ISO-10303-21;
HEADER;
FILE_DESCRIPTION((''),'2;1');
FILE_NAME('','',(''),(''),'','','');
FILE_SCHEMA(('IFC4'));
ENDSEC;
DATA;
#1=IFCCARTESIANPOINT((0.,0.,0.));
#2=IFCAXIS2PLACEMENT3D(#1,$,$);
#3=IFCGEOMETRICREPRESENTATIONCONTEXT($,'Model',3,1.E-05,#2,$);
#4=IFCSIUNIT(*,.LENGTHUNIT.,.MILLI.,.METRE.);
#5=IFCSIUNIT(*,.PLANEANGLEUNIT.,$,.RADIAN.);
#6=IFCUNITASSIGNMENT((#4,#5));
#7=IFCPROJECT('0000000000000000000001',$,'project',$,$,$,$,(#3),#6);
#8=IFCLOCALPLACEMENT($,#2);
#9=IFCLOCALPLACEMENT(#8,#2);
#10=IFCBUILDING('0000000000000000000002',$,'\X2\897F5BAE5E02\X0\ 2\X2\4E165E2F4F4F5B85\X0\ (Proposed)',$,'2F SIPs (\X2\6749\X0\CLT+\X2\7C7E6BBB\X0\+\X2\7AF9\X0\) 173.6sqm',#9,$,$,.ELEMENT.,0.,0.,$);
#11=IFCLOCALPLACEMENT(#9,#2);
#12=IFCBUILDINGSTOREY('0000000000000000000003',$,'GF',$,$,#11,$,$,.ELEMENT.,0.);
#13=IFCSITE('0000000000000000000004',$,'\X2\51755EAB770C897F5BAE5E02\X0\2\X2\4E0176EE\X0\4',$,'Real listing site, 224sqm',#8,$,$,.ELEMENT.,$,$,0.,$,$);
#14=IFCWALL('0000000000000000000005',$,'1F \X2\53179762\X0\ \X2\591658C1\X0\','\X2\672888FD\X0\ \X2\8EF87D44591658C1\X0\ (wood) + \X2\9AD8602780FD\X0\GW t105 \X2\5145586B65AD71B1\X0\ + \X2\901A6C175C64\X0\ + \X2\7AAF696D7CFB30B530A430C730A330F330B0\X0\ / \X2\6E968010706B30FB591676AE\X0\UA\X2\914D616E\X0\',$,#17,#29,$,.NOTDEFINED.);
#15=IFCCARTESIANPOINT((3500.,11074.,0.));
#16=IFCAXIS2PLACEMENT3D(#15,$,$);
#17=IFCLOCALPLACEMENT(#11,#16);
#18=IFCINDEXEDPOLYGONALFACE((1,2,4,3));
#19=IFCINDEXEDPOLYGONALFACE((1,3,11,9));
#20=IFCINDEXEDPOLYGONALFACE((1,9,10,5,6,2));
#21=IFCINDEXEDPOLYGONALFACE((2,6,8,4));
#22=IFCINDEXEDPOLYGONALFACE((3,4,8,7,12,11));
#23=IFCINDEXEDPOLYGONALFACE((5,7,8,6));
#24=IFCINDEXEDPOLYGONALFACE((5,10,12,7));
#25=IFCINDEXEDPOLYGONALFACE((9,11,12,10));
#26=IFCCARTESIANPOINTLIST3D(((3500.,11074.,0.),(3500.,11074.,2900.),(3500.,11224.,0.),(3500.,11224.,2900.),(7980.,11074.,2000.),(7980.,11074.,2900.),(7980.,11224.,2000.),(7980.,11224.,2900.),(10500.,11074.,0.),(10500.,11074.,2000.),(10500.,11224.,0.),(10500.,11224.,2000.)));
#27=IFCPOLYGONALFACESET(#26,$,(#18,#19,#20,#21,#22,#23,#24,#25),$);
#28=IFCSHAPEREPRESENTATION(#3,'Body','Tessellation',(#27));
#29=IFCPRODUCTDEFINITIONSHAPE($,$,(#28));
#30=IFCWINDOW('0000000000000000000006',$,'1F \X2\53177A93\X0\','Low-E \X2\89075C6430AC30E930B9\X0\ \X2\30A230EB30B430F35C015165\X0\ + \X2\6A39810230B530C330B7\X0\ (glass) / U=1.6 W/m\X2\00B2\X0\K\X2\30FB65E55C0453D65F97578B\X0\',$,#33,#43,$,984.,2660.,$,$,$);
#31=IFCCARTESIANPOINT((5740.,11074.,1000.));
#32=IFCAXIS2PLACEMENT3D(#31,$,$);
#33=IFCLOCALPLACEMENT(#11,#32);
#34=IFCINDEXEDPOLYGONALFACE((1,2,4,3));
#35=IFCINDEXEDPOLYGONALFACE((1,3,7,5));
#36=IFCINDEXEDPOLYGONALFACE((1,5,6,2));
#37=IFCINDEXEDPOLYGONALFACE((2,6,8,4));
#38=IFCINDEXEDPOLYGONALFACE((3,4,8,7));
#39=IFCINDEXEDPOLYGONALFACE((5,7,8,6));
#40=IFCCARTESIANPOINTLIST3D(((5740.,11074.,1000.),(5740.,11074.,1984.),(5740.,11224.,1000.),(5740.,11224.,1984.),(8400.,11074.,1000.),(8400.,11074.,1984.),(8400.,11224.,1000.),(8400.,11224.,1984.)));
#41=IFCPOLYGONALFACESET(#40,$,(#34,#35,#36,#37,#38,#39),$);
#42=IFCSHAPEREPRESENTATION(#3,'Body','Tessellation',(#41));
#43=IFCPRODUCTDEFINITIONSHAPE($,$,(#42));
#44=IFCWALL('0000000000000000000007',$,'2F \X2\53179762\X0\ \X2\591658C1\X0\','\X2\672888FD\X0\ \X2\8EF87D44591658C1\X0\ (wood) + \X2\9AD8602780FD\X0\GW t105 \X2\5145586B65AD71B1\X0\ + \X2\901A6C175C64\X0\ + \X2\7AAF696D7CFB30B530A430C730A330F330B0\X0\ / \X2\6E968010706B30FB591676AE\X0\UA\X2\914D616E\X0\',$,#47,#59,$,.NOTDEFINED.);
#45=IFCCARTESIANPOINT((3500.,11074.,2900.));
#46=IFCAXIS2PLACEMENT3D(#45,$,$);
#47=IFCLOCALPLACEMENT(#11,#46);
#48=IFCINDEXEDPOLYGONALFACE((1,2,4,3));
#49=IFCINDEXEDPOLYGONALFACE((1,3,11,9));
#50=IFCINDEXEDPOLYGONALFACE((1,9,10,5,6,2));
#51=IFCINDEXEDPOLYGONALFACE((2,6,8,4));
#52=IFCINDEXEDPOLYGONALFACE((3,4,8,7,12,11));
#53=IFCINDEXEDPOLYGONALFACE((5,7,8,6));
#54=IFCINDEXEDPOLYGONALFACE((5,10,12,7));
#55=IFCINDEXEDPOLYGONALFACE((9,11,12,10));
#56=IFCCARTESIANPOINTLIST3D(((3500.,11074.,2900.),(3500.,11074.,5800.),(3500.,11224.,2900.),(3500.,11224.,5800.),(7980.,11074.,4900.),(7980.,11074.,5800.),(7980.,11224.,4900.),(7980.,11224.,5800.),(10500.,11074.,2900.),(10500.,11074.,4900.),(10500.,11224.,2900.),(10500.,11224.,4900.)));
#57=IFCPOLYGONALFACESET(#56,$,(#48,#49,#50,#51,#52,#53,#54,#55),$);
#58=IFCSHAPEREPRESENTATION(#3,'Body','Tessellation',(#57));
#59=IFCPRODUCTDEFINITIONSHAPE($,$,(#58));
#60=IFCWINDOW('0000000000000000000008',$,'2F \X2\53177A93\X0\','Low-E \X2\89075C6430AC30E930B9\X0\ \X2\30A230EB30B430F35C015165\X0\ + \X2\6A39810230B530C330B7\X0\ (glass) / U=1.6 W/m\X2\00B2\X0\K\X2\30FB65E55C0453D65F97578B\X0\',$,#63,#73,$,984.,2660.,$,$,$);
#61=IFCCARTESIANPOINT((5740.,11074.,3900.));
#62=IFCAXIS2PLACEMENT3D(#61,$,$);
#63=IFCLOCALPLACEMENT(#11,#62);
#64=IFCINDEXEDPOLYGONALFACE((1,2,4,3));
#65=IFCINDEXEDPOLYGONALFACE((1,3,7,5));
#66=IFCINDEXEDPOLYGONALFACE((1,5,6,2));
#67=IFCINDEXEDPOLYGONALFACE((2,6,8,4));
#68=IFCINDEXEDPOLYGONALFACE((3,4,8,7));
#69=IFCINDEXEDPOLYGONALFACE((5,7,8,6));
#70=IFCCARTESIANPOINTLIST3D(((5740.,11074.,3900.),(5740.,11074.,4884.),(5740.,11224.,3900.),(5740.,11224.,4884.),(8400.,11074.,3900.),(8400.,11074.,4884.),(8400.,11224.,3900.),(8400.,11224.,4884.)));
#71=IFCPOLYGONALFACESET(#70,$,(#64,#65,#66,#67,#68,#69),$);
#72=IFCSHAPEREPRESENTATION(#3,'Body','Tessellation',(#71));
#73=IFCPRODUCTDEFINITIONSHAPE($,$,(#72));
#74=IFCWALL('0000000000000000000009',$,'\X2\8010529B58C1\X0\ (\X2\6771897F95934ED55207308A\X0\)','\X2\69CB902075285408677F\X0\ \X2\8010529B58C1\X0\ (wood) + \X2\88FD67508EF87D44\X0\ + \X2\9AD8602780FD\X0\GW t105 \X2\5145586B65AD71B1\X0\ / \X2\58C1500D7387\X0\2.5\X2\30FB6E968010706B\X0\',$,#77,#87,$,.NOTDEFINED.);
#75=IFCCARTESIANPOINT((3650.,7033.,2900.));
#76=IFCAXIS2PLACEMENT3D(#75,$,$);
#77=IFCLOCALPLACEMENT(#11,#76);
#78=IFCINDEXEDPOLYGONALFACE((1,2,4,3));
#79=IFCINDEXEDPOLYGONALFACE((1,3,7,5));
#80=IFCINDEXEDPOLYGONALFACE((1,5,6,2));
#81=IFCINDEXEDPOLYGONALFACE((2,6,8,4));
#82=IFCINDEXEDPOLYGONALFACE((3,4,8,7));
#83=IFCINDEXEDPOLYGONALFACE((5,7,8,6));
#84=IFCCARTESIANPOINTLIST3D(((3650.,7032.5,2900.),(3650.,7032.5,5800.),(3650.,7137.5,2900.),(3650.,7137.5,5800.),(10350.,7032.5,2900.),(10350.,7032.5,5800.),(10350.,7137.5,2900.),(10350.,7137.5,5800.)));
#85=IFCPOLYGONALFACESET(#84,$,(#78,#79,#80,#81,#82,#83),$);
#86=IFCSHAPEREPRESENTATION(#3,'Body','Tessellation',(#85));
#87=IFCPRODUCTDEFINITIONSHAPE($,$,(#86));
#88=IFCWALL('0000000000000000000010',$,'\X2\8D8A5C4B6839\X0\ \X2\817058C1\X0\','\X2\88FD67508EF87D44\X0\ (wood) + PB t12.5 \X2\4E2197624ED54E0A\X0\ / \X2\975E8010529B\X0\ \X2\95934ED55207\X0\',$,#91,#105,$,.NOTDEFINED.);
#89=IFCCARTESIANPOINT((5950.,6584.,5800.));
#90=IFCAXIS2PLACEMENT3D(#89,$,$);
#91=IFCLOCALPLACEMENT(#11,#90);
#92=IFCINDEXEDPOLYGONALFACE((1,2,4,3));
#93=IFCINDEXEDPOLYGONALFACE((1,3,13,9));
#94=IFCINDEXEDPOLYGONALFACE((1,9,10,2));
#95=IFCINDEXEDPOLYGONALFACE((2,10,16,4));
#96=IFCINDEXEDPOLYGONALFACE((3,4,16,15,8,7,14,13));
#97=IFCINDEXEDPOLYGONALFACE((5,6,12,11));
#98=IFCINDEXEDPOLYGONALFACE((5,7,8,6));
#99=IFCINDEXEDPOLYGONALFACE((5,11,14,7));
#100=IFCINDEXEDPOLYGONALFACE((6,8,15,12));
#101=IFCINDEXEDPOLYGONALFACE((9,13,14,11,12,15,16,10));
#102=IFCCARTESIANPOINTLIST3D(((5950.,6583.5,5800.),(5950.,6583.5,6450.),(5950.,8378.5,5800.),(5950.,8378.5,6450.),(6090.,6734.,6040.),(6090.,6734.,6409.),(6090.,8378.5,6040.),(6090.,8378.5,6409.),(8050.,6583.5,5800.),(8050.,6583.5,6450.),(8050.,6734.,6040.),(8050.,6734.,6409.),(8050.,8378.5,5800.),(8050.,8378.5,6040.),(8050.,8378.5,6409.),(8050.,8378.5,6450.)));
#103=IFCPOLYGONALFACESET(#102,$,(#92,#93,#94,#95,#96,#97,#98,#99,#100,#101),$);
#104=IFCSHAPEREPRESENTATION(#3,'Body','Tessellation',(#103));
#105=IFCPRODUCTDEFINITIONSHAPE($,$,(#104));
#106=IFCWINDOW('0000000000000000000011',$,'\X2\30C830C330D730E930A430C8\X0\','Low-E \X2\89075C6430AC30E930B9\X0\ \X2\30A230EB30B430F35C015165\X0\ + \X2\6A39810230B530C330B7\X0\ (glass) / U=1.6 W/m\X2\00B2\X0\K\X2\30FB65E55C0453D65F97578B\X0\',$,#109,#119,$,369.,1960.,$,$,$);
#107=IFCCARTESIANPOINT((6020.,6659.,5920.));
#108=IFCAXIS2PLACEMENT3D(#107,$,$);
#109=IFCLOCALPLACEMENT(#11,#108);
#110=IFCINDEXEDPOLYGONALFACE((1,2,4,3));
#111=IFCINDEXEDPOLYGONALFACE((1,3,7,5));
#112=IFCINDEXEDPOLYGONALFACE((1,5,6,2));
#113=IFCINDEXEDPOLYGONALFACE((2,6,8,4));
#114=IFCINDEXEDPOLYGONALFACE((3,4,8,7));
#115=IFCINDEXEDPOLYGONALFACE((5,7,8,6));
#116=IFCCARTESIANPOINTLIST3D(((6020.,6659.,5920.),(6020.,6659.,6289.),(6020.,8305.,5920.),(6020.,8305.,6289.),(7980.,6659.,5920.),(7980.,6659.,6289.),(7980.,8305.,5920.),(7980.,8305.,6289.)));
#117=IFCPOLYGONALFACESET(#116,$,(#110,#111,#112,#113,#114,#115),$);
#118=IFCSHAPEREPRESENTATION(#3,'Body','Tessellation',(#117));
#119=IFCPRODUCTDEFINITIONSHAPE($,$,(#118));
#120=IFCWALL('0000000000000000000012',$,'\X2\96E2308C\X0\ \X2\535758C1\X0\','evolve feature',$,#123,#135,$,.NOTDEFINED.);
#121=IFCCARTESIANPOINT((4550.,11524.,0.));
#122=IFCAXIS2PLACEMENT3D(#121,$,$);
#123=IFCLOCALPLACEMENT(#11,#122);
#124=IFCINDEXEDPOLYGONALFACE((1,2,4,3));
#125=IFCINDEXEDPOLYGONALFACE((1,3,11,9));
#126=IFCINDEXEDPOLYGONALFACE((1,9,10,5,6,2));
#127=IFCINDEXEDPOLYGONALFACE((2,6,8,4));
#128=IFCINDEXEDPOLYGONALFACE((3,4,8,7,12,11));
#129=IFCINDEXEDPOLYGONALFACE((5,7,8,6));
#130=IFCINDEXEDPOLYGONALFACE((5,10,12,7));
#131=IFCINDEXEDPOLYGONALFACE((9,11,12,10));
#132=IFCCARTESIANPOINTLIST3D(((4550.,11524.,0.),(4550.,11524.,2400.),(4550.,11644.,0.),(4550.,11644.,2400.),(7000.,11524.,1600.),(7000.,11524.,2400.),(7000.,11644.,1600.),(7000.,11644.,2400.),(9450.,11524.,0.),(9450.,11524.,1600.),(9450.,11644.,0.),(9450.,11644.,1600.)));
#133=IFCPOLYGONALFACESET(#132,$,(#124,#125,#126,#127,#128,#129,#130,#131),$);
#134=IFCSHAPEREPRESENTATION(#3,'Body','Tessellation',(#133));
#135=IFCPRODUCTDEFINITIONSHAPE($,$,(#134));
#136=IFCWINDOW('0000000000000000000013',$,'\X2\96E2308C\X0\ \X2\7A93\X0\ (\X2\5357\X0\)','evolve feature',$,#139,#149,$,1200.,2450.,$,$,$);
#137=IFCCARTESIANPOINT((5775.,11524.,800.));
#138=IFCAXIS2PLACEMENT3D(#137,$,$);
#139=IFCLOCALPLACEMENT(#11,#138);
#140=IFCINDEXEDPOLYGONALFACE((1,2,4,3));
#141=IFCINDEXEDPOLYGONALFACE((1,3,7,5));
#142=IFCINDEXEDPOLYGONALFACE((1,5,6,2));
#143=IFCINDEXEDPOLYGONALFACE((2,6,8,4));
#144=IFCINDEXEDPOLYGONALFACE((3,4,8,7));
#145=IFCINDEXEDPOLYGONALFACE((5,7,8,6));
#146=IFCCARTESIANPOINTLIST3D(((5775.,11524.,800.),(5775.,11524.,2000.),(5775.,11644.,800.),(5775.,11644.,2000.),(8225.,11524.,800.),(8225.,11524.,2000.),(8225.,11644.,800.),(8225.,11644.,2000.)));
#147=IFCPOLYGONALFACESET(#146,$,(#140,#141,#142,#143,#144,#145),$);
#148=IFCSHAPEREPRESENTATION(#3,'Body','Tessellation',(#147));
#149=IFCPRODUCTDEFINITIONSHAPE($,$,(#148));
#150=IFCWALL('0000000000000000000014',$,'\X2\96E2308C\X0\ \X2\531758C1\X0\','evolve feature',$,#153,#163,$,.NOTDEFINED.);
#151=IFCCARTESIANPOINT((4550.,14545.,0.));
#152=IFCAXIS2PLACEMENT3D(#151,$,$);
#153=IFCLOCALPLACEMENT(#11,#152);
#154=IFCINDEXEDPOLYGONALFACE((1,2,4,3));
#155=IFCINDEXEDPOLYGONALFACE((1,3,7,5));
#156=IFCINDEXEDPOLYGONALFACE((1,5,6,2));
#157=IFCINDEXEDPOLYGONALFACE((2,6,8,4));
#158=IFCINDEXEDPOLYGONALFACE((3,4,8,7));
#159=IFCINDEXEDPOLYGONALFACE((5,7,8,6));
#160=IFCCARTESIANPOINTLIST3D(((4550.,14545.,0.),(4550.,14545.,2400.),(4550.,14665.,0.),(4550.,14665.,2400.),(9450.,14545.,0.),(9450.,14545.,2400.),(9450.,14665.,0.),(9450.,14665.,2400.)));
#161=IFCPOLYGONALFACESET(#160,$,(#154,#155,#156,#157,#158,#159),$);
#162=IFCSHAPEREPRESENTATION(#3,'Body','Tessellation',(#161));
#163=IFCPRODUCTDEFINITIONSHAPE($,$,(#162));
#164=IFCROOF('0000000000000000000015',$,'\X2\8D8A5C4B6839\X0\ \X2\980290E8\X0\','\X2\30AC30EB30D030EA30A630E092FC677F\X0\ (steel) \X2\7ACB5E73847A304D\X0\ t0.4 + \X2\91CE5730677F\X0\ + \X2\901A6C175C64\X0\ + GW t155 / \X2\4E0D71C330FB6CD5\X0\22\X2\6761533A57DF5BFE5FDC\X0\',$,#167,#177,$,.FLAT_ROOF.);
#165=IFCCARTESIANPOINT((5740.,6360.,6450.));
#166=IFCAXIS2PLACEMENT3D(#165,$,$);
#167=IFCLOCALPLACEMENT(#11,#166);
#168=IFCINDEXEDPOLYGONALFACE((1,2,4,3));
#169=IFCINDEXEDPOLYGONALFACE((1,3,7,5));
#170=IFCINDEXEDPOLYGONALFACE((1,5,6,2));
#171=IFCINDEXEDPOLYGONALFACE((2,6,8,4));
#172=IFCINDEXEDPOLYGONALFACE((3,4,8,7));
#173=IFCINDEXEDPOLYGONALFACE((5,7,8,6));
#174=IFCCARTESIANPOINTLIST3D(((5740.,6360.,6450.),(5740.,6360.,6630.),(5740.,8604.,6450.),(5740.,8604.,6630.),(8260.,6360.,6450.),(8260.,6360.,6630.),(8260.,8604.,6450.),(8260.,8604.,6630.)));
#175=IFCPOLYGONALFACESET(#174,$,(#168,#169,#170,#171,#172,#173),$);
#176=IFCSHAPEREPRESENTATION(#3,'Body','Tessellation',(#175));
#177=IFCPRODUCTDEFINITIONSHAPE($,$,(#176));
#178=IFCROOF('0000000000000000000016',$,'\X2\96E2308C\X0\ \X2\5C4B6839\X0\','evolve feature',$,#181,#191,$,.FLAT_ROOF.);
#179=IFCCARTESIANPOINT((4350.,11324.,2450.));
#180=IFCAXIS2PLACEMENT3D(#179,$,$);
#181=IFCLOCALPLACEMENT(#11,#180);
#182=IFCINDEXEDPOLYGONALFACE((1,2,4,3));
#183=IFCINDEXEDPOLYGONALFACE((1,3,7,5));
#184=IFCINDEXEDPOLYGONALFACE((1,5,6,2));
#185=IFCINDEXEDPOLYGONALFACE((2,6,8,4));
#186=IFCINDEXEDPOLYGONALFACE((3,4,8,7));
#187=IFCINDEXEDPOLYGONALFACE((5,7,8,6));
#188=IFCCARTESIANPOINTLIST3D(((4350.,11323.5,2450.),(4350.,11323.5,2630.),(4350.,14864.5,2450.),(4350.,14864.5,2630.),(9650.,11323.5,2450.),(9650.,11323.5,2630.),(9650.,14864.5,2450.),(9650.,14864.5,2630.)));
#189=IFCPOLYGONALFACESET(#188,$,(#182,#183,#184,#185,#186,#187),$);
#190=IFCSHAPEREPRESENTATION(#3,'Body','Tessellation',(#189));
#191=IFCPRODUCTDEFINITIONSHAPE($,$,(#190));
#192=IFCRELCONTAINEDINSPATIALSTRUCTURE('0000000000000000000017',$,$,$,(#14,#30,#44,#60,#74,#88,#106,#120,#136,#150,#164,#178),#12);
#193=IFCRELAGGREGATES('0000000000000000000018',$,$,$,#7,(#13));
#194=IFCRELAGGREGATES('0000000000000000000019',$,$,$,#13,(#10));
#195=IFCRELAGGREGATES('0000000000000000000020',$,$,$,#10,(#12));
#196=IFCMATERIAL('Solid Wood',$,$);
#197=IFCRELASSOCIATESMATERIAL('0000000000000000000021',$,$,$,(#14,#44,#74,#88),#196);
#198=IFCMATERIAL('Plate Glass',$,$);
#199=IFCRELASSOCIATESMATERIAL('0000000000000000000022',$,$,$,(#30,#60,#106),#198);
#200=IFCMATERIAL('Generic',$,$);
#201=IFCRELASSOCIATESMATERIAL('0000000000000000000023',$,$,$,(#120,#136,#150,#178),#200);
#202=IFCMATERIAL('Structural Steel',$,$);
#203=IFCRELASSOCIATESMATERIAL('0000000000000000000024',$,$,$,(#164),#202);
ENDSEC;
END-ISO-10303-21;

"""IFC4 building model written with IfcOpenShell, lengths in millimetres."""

from ifc_helpers import new_model, si_unit, frame, frame_2d, origin, place, context, project, spatial, rectangle, extrude, material, element, fill, save


model = new_model("IFC4")

# Units and contexts
model_context = context("Model", 3, precision=1e-05, world=origin())
ifc_project = project(units=[si_unit("LENGTHUNIT", "METRE", prefix="MILLI"), si_unit("PLANEANGLEUNIT", "RADIAN")], contexts=[model_context])

# Site, building, storey
site_placement = place(None, origin())
site = spatial("IfcSite", under=ifc_project, at=site_placement, Name="兵庫県西宮市2丁目4", ObjectType="Real listing site, 224sqm", CompositionType="ELEMENT", RefElevation=0.0)
building_placement = place(site_placement, origin())
building = spatial("IfcBuilding", under=site, at=building_placement, Name="西宮市 2世帯住宅 (Proposed)", ObjectType="2F SIPs (杉CLT+籾殻+竹) 173.6sqm", CompositionType="ELEMENT", ElevationOfRefHeight=0.0, ElevationOfTerrain=0.0)
storey_placement = place(building_placement, origin())
storey = spatial("IfcBuildingStorey", under=building, at=storey_placement, Name="GF", CompositionType="ELEMENT", Elevation=0.0)

# Shared definitions
ifc_material_1 = material(Name="Generic")

# Wall, opening, window
ifc_material_2 = material(Name="Solid Wood")
wall_1_placement = place(storey_placement, frame((3500.0, 11074.0, 0.0)))
wall_1 = element("IfcWall", 1, at=wall_1_placement, inside=storey, material=ifc_material_2, Name="1F 北面 外壁", Description="木製 軸組外壁 (wood) + 高性能GW t105 充填断熱 + 通気層 + 窯業系サイディング / 準耐火・外皮UA配慮", PredefinedType="NOTDEFINED", context=model_context, shape_type="SweptSolid", body=[
    extrude(rectangle(XDim=7000.0, YDim=150.0, at=frame_2d((3500.0, 75.0))), frame((3500.0, 11074.0, 0.0)), (0.0, 0.0, 1.0), 2900.0),
])
opening_1_placement = place(storey_placement, frame((5740.0, 11074.0, 1000.0)))
opening_1 = element("IfcOpeningElement", 2, at=opening_1_placement, cuts=wall_1, PredefinedType="NOTDEFINED", context=model_context, shape_type="SweptSolid", body=[
    extrude(rectangle(XDim=2660.0, YDim=150.0, at=frame_2d((1330.0, 75.0))), frame((5740.0, 11074.0, 1000.0)), (0.0, 0.0, 1.0), 984.0),
])
ifc_material_3 = material(Name="Plate Glass")
window_1_placement = place(storey_placement, frame((5740.0, 11074.0, 1000.0)))
window_1 = element("IfcWindow", 3, at=window_1_placement, inside=storey, material=ifc_material_3, Name="1F 北窓", Description="Low-E 複層ガラス アルゴン封入 + 樹脂サッシ (glass) / U=1.6 W/m²K・日射取得型", OverallHeight=984.0, OverallWidth=2660.0, context=model_context, shape_type="SweptSolid", body=[
    extrude(rectangle(XDim=2660.0, YDim=150.0, at=frame_2d((1330.0, 75.0))), frame((5740.0, 11074.0, 1000.0)), (0.0, 0.0, 1.0), 984.0),
])
fill(opening_1, window_1)

# Wall, opening, window
wall_2_placement = place(storey_placement, frame((3500.0, 11074.0, 2900.0)))
wall_2 = element("IfcWall", 4, at=wall_2_placement, inside=storey, material=ifc_material_2, Name="2F 北面 外壁", Description="木製 軸組外壁 (wood) + 高性能GW t105 充填断熱 + 通気層 + 窯業系サイディング / 準耐火・外皮UA配慮", PredefinedType="NOTDEFINED", context=model_context, shape_type="SweptSolid", body=[
    extrude(rectangle(XDim=7000.0, YDim=150.0, at=frame_2d((3500.0, 75.0))), frame((3500.0, 11074.0, 2900.0)), (0.0, 0.0, 1.0), 2900.0),
])
opening_2_placement = place(storey_placement, frame((5740.0, 11074.0, 3900.0)))
opening_2 = element("IfcOpeningElement", 5, at=opening_2_placement, cuts=wall_2, PredefinedType="NOTDEFINED", context=model_context, shape_type="SweptSolid", body=[
    extrude(rectangle(XDim=2660.0, YDim=150.0, at=frame_2d((1330.0, 75.0))), frame((5740.0, 11074.0, 3900.0)), (0.0, 0.0, 1.0), 984.0),
])
window_2_placement = place(storey_placement, frame((5740.0, 11074.0, 3900.0)))
window_2 = element("IfcWindow", 6, at=window_2_placement, inside=storey, material=ifc_material_3, Name="2F 北窓", Description="Low-E 複層ガラス アルゴン封入 + 樹脂サッシ (glass) / U=1.6 W/m²K・日射取得型", OverallHeight=984.0, OverallWidth=2660.0, context=model_context, shape_type="SweptSolid", body=[
    extrude(rectangle(XDim=2660.0, YDim=150.0, at=frame_2d((1330.0, 75.0))), frame((5740.0, 11074.0, 3900.0)), (0.0, 0.0, 1.0), 984.0),
])
fill(opening_2, window_2)

# Wall
wall_3_placement = place(storey_placement, frame((3650.0, 7033.0, 2900.0)))
element("IfcWall", 7, at=wall_3_placement, inside=storey, material=ifc_material_2, Name="耐力壁 (東西間仕切り)", Description="構造用合板 耐力壁 (wood) + 製材軸組 + 高性能GW t105 充填断熱 / 壁倍率2.5・準耐火", PredefinedType="NOTDEFINED", context=model_context, shape_type="SweptSolid", body=[
    extrude(rectangle(XDim=6700.0, YDim=105.0, at=frame_2d((3350.0, 52.0))), frame((3650.0, 7033.0, 2900.0)), (0.0, 0.0, 1.0), 2900.0),
])

# Walls, openings, windows
wall_4_placement = place(storey_placement, frame((5950.0, 6584.0, 5800.0)))
wall_4 = element("IfcWall", 8, at=wall_4_placement, inside=storey, material=ifc_material_2, Name="越屋根 腰壁", Description="製材軸組 (wood) + PB t12.5 両面仕上 / 非耐力 間仕切", PredefinedType="NOTDEFINED", context=model_context, shape_type="SweptSolid", body=[
    extrude(rectangle(XDim=2100.0, YDim=1795.0, at=frame_2d((1050.0, 897.0))), frame((5950.0, 6584.0, 5800.0)), (0.0, 0.0, 1.0), 650.0),
])
opening_3_placement = place(storey_placement, frame((6020.0, 6659.0, 5920.0)))
opening_3 = element("IfcOpeningElement", 9, at=opening_3_placement, cuts=wall_4, PredefinedType="NOTDEFINED", context=model_context, shape_type="SweptSolid", body=[
    extrude(rectangle(XDim=1960.0, YDim=1646.0, at=frame_2d((980.0, 823.0))), frame((6020.0, 6659.0, 5920.0)), (0.0, 0.0, 1.0), 369.0),
])
window_3_placement = place(storey_placement, frame((6020.0, 6659.0, 5920.0)))
window_3 = element("IfcWindow", 10, at=window_3_placement, inside=storey, material=ifc_material_3, Name="トップライト", Description="Low-E 複層ガラス アルゴン封入 + 樹脂サッシ (glass) / U=1.6 W/m²K・日射取得型", OverallHeight=369.0, OverallWidth=1960.0, context=model_context, shape_type="SweptSolid", body=[
    extrude(rectangle(XDim=1960.0, YDim=1646.0, at=frame_2d((980.0, 823.0))), frame((6020.0, 6659.0, 5920.0)), (0.0, 0.0, 1.0), 369.0),
])
fill(opening_3, window_3)
wall_5_placement = place(storey_placement, frame((4550.0, 11524.0, 0.0)))
wall_5 = element("IfcWall", 11, at=wall_5_placement, inside=storey, material=ifc_material_1, Name="離れ 南壁", Description="evolve feature", PredefinedType="NOTDEFINED", context=model_context, shape_type="SweptSolid", body=[
    extrude(rectangle(XDim=4900.0, YDim=120.0, at=frame_2d((2450.0, 60.0))), frame((4550.0, 11524.0, 0.0)), (0.0, 0.0, 1.0), 2400.0),
])
opening_4_placement = place(storey_placement, frame((5775.0, 11524.0, 800.0)))
opening_4 = element("IfcOpeningElement", 12, at=opening_4_placement, cuts=wall_5, PredefinedType="NOTDEFINED", context=model_context, shape_type="SweptSolid", body=[
    extrude(rectangle(XDim=2450.0, YDim=120.0, at=frame_2d((1225.0, 60.0))), frame((5775.0, 11524.0, 800.0)), (0.0, 0.0, 1.0), 1200.0),
])
window_4_placement = place(storey_placement, frame((5775.0, 11524.0, 800.0)))
window_4 = element("IfcWindow", 13, at=window_4_placement, inside=storey, material=ifc_material_1, Name="離れ 窓 (南)", Description="evolve feature", OverallHeight=1200.0, OverallWidth=2450.0, context=model_context, shape_type="SweptSolid", body=[
    extrude(rectangle(XDim=2450.0, YDim=120.0, at=frame_2d((1225.0, 60.0))), frame((5775.0, 11524.0, 800.0)), (0.0, 0.0, 1.0), 1200.0),
])
fill(opening_4, window_4)

# Wall
wall_6_placement = place(storey_placement, frame((4550.0, 14545.0, 0.0)))
element("IfcWall", 14, at=wall_6_placement, inside=storey, material=ifc_material_1, Name="離れ 北壁", Description="evolve feature", PredefinedType="NOTDEFINED", context=model_context, shape_type="SweptSolid", body=[
    extrude(rectangle(XDim=4900.0, YDim=120.0, at=frame_2d((2450.0, 60.0))), frame((4550.0, 14545.0, 0.0)), (0.0, 0.0, 1.0), 2400.0),
])

# Roofs
ifc_material_4 = material(Name="Structural Steel")
roof_1_placement = place(storey_placement, frame((5740.0, 6360.0, 6450.0)))
element("IfcRoof", 15, at=roof_1_placement, inside=storey, material=ifc_material_4, Name="越屋根 頂部", Description="ガルバリウム鋼板 (steel) 立平葺き t0.4 + 野地板 + 通気層 + GW t155 / 不燃・法22条区域対応", PredefinedType="FLAT_ROOF", context=model_context, shape_type="SweptSolid", body=[
    extrude(rectangle(XDim=2520.0, YDim=2244.0, at=frame_2d((1260.0, 1122.0))), frame((5740.0, 6360.0, 6450.0)), (0.0, 0.0, 1.0), 180.0),
])
roof_2_placement = place(storey_placement, frame((4350.0, 11324.0, 2450.0)))
element("IfcRoof", 16, at=roof_2_placement, inside=storey, material=ifc_material_1, Name="離れ 屋根", Description="evolve feature", PredefinedType="FLAT_ROOF", context=model_context, shape_type="SweptSolid", body=[
    extrude(rectangle(XDim=5300.0, YDim=3541.0, at=frame_2d((2650.0, 1770.0))), frame((4350.0, 11324.0, 2450.0)), (0.0, 0.0, 1.0), 180.0),
])

save(model, "model.ifc")
